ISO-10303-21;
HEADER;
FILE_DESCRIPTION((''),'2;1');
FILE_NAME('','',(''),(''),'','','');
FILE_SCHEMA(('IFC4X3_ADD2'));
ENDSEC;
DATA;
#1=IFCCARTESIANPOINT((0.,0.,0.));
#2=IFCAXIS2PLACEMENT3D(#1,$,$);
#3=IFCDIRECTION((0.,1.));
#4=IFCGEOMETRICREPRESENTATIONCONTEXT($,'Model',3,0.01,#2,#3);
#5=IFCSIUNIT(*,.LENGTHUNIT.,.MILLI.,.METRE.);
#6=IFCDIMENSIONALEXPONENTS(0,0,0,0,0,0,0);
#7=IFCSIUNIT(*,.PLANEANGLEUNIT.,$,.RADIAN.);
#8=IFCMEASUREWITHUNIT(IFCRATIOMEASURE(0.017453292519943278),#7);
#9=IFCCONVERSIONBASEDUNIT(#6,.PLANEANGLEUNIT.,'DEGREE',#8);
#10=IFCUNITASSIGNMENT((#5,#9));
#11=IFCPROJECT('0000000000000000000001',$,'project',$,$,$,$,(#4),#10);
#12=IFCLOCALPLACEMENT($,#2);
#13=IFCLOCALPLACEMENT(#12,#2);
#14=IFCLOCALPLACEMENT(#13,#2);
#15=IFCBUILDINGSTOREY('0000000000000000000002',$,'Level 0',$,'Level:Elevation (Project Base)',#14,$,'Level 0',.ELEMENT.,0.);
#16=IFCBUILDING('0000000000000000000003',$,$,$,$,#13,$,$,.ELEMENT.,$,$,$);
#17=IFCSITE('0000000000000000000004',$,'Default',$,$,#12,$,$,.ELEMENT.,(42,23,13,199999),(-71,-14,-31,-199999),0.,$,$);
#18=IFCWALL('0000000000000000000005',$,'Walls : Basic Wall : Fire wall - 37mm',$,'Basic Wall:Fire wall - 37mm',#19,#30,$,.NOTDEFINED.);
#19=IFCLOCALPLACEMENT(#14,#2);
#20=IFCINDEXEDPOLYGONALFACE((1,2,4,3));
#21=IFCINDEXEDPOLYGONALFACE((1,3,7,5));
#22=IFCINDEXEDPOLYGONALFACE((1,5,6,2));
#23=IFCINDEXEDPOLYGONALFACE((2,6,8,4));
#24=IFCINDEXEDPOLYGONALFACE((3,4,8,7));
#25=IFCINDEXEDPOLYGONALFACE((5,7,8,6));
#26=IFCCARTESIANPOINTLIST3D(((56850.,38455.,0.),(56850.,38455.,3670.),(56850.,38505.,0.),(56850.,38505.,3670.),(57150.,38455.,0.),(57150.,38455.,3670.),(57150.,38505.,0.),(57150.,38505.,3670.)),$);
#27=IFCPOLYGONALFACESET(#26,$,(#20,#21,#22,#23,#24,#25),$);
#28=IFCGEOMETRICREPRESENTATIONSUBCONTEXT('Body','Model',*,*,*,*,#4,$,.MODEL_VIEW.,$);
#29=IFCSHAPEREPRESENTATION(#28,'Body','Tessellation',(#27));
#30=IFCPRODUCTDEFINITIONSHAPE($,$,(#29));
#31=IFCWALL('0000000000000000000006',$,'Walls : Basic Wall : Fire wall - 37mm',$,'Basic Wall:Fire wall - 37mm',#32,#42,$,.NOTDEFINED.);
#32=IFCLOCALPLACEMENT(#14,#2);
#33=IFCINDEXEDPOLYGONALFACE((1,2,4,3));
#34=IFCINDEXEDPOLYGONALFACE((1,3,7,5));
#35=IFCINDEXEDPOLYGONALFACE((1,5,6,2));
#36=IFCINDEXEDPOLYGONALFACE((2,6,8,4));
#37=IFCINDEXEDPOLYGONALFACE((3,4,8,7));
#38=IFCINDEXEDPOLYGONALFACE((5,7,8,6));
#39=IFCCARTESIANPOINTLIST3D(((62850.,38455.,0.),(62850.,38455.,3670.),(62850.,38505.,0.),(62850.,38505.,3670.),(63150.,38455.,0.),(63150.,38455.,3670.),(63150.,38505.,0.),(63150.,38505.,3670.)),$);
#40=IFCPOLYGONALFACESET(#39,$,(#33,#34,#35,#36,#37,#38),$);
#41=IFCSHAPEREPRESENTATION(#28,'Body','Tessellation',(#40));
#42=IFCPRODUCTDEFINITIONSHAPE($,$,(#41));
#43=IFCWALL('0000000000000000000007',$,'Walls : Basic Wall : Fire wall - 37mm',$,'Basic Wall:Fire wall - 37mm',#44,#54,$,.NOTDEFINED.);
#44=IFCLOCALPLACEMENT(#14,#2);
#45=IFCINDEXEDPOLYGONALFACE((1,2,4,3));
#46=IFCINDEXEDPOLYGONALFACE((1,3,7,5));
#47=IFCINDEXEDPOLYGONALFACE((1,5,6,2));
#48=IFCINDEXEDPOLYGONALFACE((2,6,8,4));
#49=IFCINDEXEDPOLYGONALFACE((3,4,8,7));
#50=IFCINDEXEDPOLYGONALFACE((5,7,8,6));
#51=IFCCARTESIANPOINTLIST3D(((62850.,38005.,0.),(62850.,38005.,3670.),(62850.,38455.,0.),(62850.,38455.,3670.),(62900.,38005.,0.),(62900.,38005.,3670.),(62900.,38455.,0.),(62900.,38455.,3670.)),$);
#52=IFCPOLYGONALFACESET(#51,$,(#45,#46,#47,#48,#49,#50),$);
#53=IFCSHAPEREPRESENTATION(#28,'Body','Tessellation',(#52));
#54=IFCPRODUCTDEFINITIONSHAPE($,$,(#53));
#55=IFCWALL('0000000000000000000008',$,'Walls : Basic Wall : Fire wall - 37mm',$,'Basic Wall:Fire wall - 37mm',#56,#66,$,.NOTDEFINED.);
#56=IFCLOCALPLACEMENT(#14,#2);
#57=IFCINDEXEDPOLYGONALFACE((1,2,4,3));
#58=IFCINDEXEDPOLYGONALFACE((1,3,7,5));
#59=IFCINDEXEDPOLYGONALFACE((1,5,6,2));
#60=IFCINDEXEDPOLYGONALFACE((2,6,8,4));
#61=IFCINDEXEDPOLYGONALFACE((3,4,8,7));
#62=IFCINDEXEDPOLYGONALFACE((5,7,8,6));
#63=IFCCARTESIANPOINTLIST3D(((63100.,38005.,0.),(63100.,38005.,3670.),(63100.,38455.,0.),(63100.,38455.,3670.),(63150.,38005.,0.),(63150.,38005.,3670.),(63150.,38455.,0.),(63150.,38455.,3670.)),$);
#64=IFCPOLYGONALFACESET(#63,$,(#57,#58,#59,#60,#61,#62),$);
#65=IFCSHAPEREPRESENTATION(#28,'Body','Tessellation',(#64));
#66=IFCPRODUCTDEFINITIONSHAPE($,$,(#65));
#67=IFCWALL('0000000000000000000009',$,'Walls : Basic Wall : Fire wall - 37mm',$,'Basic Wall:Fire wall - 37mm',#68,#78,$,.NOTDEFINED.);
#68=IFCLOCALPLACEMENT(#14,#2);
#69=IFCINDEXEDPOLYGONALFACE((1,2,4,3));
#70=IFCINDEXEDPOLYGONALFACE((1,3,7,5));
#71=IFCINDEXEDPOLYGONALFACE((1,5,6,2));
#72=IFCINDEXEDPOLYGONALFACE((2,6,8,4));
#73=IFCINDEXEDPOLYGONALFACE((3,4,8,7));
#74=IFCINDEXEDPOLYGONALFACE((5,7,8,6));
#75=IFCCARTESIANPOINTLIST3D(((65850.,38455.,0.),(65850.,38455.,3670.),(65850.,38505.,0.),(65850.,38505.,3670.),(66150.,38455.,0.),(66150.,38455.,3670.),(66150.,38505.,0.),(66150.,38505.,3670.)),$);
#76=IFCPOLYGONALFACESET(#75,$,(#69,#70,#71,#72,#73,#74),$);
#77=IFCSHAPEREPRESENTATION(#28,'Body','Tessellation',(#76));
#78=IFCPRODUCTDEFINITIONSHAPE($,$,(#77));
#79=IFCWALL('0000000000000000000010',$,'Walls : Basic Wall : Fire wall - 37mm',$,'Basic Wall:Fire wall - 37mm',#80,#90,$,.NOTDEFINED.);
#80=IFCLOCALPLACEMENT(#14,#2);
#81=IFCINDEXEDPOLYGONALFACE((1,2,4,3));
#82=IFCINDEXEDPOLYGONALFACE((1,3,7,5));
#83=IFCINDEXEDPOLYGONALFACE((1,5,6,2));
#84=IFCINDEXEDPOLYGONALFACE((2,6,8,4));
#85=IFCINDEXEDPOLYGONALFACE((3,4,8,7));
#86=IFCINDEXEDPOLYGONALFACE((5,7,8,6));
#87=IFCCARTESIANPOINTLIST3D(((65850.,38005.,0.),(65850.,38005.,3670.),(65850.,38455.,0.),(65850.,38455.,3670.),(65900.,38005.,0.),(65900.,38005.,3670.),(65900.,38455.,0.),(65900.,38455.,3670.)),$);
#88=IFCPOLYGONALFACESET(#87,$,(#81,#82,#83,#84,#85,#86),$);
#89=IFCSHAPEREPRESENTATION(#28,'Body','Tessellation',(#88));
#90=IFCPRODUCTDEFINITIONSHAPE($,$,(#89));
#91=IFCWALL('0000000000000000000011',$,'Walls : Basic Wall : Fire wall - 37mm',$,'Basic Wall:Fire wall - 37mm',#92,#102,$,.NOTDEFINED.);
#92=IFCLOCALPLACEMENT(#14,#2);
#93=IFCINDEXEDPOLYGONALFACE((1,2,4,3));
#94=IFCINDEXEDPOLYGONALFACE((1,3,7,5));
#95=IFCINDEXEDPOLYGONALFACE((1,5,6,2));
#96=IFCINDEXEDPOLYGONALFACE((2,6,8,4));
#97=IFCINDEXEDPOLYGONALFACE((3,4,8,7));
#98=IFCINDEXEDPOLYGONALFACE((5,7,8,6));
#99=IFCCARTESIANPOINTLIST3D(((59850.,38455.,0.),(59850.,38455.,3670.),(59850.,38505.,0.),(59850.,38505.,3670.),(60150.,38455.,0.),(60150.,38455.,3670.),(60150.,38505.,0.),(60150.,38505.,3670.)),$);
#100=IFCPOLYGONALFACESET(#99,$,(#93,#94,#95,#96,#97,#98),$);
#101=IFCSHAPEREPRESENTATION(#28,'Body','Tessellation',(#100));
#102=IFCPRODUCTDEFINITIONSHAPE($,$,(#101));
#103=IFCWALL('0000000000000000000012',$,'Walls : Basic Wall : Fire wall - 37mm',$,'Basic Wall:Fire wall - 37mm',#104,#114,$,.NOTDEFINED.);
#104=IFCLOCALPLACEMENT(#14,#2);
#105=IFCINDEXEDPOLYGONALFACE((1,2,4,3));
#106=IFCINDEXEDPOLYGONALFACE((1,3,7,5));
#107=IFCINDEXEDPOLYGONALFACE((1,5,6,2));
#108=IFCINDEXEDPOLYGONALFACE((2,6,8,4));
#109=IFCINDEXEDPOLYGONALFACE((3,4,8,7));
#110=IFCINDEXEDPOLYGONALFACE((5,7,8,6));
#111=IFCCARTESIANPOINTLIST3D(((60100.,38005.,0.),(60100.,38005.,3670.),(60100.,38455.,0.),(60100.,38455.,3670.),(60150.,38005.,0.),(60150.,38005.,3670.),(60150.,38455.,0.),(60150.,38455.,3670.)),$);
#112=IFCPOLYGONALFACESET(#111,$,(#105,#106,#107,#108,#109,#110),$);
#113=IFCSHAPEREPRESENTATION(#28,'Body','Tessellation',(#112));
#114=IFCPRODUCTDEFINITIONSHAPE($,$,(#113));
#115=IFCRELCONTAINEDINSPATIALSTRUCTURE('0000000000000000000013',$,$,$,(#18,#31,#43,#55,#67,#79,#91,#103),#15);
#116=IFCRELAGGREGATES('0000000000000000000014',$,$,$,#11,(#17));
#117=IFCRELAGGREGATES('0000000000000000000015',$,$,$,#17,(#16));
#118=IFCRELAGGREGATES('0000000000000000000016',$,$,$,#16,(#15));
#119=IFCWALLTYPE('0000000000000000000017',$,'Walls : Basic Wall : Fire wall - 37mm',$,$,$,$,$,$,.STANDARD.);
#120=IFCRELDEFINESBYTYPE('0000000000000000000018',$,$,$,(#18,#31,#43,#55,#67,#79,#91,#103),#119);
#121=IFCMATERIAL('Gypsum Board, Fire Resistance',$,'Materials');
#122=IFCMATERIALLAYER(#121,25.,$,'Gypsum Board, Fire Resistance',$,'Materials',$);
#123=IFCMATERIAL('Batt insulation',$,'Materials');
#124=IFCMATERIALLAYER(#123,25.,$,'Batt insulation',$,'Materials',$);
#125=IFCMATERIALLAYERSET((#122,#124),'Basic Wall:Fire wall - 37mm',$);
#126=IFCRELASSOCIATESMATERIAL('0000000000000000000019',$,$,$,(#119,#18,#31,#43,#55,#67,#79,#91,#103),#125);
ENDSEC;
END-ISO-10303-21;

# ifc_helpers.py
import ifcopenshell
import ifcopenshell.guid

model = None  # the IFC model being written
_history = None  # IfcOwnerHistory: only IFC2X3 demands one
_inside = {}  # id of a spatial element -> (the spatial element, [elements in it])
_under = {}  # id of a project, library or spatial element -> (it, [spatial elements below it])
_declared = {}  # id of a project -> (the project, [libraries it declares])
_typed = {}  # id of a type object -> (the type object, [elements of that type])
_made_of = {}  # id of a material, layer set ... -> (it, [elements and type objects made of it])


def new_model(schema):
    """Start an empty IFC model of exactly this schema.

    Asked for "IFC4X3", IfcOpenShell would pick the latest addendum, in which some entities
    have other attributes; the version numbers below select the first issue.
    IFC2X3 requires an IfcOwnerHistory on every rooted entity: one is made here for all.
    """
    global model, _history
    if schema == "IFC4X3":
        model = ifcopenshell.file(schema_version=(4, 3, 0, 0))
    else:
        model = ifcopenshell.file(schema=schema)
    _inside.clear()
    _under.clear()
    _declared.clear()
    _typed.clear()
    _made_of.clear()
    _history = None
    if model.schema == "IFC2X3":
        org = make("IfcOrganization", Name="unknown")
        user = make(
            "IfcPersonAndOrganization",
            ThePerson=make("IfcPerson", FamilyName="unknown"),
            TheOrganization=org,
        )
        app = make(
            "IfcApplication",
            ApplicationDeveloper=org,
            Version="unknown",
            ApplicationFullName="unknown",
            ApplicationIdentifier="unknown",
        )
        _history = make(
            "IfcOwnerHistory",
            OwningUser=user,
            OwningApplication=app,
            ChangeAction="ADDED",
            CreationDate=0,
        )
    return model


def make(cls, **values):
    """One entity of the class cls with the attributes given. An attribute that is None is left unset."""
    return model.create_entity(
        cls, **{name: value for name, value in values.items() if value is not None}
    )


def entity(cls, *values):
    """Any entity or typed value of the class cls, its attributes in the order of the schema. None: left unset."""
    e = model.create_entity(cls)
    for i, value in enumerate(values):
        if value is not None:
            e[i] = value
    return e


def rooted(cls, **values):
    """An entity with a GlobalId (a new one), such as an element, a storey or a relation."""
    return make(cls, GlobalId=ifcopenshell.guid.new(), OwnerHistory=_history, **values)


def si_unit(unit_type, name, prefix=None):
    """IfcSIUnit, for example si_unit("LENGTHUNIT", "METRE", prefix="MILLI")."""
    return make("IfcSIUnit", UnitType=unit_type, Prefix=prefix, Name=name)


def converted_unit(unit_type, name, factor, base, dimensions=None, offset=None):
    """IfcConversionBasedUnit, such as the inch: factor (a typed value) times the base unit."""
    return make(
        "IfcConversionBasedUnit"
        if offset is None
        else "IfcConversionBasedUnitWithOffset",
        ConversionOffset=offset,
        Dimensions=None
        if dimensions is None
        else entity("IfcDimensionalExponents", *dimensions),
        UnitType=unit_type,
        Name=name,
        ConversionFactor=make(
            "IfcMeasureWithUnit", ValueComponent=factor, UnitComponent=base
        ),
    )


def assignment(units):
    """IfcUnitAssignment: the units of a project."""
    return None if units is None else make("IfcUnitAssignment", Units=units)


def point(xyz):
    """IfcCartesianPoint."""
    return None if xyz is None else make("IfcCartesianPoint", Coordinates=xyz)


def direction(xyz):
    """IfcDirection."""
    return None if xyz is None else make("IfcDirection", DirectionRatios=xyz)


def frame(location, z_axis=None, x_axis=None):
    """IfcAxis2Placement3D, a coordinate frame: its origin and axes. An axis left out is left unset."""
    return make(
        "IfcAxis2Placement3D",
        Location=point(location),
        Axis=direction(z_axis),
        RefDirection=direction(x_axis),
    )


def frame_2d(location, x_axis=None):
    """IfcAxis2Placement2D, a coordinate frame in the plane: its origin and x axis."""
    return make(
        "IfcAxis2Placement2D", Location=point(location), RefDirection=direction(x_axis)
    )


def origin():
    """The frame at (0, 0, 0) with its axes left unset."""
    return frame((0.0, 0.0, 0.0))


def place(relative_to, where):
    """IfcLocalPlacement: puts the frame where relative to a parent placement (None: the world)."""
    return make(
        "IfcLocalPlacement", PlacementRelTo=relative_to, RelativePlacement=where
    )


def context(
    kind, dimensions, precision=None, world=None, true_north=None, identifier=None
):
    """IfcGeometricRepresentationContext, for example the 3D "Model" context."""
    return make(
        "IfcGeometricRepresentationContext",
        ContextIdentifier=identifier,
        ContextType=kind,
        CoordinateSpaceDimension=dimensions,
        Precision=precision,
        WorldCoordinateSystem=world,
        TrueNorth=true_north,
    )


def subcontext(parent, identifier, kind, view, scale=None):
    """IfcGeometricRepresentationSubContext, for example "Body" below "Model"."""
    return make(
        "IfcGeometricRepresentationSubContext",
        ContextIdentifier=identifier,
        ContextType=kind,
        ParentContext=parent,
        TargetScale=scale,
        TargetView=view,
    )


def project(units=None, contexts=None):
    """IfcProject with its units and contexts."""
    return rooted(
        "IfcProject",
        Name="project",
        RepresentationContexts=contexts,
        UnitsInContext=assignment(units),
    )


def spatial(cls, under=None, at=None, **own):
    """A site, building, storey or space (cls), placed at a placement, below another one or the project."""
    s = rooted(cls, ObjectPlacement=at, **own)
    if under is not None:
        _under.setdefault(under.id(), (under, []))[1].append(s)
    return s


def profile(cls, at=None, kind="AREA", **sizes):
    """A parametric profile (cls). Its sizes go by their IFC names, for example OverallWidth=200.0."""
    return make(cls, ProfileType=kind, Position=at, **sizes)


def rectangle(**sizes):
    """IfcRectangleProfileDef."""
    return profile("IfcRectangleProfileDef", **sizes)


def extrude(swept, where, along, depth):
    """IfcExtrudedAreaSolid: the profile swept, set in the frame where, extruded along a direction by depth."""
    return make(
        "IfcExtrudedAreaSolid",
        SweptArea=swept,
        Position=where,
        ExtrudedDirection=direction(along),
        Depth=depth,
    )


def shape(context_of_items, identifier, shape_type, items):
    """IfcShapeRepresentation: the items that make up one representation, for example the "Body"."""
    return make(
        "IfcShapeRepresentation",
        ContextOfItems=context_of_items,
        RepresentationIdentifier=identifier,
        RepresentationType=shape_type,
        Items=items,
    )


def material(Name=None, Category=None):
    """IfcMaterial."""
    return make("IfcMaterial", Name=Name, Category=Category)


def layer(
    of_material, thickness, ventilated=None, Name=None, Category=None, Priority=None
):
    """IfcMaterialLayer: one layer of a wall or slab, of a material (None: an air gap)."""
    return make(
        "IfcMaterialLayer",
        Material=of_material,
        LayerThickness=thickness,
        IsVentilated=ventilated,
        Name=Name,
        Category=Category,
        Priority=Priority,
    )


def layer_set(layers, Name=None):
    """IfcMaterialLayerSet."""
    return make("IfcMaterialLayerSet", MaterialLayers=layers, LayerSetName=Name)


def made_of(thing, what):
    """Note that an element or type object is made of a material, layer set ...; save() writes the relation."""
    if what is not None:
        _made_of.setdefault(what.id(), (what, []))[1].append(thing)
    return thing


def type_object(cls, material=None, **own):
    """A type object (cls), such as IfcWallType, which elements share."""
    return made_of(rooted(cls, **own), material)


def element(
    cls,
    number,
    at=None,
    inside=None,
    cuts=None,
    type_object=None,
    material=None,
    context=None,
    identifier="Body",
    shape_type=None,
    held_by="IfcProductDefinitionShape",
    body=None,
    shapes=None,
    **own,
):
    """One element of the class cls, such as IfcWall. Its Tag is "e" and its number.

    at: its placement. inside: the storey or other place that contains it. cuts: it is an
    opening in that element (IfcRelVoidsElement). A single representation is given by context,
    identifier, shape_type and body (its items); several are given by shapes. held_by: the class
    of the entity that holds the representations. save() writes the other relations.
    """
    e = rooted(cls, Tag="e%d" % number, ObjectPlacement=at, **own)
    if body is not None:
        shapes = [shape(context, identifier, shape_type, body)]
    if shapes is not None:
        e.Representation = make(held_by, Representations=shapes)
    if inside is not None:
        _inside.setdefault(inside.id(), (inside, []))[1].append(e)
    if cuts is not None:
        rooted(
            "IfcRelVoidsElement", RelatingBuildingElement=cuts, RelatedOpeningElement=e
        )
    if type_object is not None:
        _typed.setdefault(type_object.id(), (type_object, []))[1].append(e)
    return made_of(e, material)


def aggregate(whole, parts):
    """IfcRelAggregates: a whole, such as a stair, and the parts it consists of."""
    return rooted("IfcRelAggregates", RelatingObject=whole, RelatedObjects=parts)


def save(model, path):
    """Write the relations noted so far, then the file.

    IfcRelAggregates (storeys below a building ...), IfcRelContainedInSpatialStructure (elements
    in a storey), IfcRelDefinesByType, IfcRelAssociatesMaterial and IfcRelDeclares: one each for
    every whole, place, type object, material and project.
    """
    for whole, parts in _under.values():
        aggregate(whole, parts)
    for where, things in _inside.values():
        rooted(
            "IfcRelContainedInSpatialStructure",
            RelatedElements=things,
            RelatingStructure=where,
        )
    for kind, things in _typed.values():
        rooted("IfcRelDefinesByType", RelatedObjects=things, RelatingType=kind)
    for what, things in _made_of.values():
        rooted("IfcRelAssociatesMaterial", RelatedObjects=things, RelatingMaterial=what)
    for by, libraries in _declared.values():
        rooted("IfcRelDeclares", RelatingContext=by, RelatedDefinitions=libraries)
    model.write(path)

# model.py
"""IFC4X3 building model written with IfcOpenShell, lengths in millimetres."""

from ifc_helpers import new_model, entity, si_unit, converted_unit, direction, frame, frame_2d, origin, place, context, subcontext, project, spatial, rectangle, extrude, material, layer, layer_set, type_object, element, save


model = new_model("IFC4X3")

# Units and contexts
model_context = context("Model", 3, precision=0.01, world=origin(), true_north=direction((0.0, 1.0)))
body_context = subcontext(model_context, "Body", "Model", "MODEL_VIEW")
ifc_project = project(units=[si_unit("LENGTHUNIT", "METRE", prefix="MILLI"), converted_unit("PLANEANGLEUNIT", "DEGREE", entity("IfcRatioMeasure", 0.017453292519943278), si_unit("PLANEANGLEUNIT", "RADIAN"), dimensions=[0, 0, 0, 0, 0, 0, 0])], contexts=[model_context])

# Site, building, storey
site_placement = place(None, origin())
site = spatial("IfcSite", under=ifc_project, at=site_placement, Name="Default", CompositionType="ELEMENT", RefLatitude=(42, 23, 13, 199999), RefLongitude=(-71, -14, -31, -199999), RefElevation=0.0)
building_placement = place(site_placement, origin())
building = spatial("IfcBuilding", under=site, at=building_placement, CompositionType="ELEMENT")
storey_placement = place(building_placement, origin())
storey = spatial("IfcBuildingStorey", under=building, at=storey_placement, Name="Level 0", ObjectType="Level:Elevation (Project Base)", LongName="Level 0", CompositionType="ELEMENT", Elevation=0.0)

# Walls
ifc_material_1 = material(Name="Gypsum Board, Fire Resistance", Category="Materials")
ifc_layer_1 = layer(ifc_material_1, 25.0, Name="Gypsum Board, Fire Resistance", Category="Materials")
ifc_material_2 = material(Name="Batt insulation", Category="Materials")
ifc_layer_2 = layer(ifc_material_2, 25.0, Name="Batt insulation", Category="Materials")
ifc_layer_set = layer_set([ifc_layer_1, ifc_layer_2], Name="Basic Wall:Fire wall - 37mm")
wall_type = type_object("IfcWallType", Name="Walls : Basic Wall : Fire wall - 37mm", PredefinedType="STANDARD", material=ifc_layer_set)
for number, where, name in (
    (1, (56850.0, 38480.0, 0.0), "Walls : Basic Wall : Fire wall - 37mm"),
    (2, (62850.0, 38480.0, 0.0), "Walls : Basic Wall : Fire wall - 37mm"),
):
    element("IfcWall", number, at=place(storey_placement, frame(where)), inside=storey, type_object=wall_type, material=ifc_layer_set, Name=name, ObjectType="Basic Wall:Fire wall - 37mm", PredefinedType="NOTDEFINED", context=body_context, shape_type="SweptSolid", body=[
        extrude(rectangle(XDim=300.0, YDim=50.0, at=frame_2d((150.0, 0.0), x_axis=(-1.0, 0.0))), origin(), (0.0, 0.0, 1.0), 3670.0),
    ])
for number, where, z_axis, x_axis, name in (
    (3, (62875.0, 38455.0, 0.0), (0.0, 0.0, 1.0), (0.0, -1.0, 0.0), "Walls : Basic Wall : Fire wall - 37mm"),
    (4, (63125.0, 38455.0, 0.0), (0.0, 0.0, 1.0), (0.0, -1.0, 0.0), "Walls : Basic Wall : Fire wall - 37mm"),
):
    element("IfcWall", number, at=place(storey_placement, frame(where, z_axis=z_axis, x_axis=x_axis)), inside=storey, type_object=wall_type, material=ifc_layer_set, Name=name, ObjectType="Basic Wall:Fire wall - 37mm", PredefinedType="NOTDEFINED", context=body_context, shape_type="SweptSolid", body=[
        extrude(rectangle(XDim=450.0, YDim=50.0, at=frame_2d((225.0, 0.0), x_axis=(-1.0, 0.0))), origin(), (0.0, 0.0, 1.0), 3670.0),
    ])
wall_1_placement = place(storey_placement, frame((65850.0, 38480.0, 0.0)))
element("IfcWall", 5, at=wall_1_placement, inside=storey, type_object=wall_type, material=ifc_layer_set, Name="Walls : Basic Wall : Fire wall - 37mm", ObjectType="Basic Wall:Fire wall - 37mm", PredefinedType="NOTDEFINED", context=body_context, shape_type="SweptSolid", body=[
    extrude(rectangle(XDim=300.0, YDim=50.0, at=frame_2d((150.0, 0.0), x_axis=(-1.0, 0.0))), origin(), (0.0, 0.0, 1.0), 3670.0),
])
wall_2_placement = place(storey_placement, frame((65875.0, 38455.0, 0.0), z_axis=(0.0, 0.0, 1.0), x_axis=(0.0, -1.0, 0.0)))
element("IfcWall", 6, at=wall_2_placement, inside=storey, type_object=wall_type, material=ifc_layer_set, Name="Walls : Basic Wall : Fire wall - 37mm", ObjectType="Basic Wall:Fire wall - 37mm", PredefinedType="NOTDEFINED", context=body_context, shape_type="SweptSolid", body=[
    extrude(rectangle(XDim=450.0, YDim=50.0, at=frame_2d((225.0, 0.0), x_axis=(-1.0, 0.0))), origin(), (0.0, 0.0, 1.0), 3670.0),
])
wall_3_placement = place(storey_placement, frame((59850.0, 38480.0, 0.0)))
element("IfcWall", 7, at=wall_3_placement, inside=storey, type_object=wall_type, material=ifc_layer_set, Name="Walls : Basic Wall : Fire wall - 37mm", ObjectType="Basic Wall:Fire wall - 37mm", PredefinedType="NOTDEFINED", context=body_context, shape_type="SweptSolid", body=[
    extrude(rectangle(XDim=300.0, YDim=50.0, at=frame_2d((150.0, 0.0), x_axis=(-1.0, 0.0))), origin(), (0.0, 0.0, 1.0), 3670.0),
])
wall_4_placement = place(storey_placement, frame((60125.0, 38455.0, 0.0), z_axis=(0.0, 0.0, 1.0), x_axis=(0.0, -1.0, 0.0)))
element("IfcWall", 8, at=wall_4_placement, inside=storey, type_object=wall_type, material=ifc_layer_set, Name="Walls : Basic Wall : Fire wall - 37mm", ObjectType="Basic Wall:Fire wall - 37mm", PredefinedType="NOTDEFINED", context=body_context, shape_type="SweptSolid", body=[
    extrude(rectangle(XDim=450.0, YDim=50.0, at=frame_2d((225.0, 0.0), x_axis=(-1.0, 0.0))), origin(), (0.0, 0.0, 1.0), 3670.0),
])

save(model, "model.ifc")
